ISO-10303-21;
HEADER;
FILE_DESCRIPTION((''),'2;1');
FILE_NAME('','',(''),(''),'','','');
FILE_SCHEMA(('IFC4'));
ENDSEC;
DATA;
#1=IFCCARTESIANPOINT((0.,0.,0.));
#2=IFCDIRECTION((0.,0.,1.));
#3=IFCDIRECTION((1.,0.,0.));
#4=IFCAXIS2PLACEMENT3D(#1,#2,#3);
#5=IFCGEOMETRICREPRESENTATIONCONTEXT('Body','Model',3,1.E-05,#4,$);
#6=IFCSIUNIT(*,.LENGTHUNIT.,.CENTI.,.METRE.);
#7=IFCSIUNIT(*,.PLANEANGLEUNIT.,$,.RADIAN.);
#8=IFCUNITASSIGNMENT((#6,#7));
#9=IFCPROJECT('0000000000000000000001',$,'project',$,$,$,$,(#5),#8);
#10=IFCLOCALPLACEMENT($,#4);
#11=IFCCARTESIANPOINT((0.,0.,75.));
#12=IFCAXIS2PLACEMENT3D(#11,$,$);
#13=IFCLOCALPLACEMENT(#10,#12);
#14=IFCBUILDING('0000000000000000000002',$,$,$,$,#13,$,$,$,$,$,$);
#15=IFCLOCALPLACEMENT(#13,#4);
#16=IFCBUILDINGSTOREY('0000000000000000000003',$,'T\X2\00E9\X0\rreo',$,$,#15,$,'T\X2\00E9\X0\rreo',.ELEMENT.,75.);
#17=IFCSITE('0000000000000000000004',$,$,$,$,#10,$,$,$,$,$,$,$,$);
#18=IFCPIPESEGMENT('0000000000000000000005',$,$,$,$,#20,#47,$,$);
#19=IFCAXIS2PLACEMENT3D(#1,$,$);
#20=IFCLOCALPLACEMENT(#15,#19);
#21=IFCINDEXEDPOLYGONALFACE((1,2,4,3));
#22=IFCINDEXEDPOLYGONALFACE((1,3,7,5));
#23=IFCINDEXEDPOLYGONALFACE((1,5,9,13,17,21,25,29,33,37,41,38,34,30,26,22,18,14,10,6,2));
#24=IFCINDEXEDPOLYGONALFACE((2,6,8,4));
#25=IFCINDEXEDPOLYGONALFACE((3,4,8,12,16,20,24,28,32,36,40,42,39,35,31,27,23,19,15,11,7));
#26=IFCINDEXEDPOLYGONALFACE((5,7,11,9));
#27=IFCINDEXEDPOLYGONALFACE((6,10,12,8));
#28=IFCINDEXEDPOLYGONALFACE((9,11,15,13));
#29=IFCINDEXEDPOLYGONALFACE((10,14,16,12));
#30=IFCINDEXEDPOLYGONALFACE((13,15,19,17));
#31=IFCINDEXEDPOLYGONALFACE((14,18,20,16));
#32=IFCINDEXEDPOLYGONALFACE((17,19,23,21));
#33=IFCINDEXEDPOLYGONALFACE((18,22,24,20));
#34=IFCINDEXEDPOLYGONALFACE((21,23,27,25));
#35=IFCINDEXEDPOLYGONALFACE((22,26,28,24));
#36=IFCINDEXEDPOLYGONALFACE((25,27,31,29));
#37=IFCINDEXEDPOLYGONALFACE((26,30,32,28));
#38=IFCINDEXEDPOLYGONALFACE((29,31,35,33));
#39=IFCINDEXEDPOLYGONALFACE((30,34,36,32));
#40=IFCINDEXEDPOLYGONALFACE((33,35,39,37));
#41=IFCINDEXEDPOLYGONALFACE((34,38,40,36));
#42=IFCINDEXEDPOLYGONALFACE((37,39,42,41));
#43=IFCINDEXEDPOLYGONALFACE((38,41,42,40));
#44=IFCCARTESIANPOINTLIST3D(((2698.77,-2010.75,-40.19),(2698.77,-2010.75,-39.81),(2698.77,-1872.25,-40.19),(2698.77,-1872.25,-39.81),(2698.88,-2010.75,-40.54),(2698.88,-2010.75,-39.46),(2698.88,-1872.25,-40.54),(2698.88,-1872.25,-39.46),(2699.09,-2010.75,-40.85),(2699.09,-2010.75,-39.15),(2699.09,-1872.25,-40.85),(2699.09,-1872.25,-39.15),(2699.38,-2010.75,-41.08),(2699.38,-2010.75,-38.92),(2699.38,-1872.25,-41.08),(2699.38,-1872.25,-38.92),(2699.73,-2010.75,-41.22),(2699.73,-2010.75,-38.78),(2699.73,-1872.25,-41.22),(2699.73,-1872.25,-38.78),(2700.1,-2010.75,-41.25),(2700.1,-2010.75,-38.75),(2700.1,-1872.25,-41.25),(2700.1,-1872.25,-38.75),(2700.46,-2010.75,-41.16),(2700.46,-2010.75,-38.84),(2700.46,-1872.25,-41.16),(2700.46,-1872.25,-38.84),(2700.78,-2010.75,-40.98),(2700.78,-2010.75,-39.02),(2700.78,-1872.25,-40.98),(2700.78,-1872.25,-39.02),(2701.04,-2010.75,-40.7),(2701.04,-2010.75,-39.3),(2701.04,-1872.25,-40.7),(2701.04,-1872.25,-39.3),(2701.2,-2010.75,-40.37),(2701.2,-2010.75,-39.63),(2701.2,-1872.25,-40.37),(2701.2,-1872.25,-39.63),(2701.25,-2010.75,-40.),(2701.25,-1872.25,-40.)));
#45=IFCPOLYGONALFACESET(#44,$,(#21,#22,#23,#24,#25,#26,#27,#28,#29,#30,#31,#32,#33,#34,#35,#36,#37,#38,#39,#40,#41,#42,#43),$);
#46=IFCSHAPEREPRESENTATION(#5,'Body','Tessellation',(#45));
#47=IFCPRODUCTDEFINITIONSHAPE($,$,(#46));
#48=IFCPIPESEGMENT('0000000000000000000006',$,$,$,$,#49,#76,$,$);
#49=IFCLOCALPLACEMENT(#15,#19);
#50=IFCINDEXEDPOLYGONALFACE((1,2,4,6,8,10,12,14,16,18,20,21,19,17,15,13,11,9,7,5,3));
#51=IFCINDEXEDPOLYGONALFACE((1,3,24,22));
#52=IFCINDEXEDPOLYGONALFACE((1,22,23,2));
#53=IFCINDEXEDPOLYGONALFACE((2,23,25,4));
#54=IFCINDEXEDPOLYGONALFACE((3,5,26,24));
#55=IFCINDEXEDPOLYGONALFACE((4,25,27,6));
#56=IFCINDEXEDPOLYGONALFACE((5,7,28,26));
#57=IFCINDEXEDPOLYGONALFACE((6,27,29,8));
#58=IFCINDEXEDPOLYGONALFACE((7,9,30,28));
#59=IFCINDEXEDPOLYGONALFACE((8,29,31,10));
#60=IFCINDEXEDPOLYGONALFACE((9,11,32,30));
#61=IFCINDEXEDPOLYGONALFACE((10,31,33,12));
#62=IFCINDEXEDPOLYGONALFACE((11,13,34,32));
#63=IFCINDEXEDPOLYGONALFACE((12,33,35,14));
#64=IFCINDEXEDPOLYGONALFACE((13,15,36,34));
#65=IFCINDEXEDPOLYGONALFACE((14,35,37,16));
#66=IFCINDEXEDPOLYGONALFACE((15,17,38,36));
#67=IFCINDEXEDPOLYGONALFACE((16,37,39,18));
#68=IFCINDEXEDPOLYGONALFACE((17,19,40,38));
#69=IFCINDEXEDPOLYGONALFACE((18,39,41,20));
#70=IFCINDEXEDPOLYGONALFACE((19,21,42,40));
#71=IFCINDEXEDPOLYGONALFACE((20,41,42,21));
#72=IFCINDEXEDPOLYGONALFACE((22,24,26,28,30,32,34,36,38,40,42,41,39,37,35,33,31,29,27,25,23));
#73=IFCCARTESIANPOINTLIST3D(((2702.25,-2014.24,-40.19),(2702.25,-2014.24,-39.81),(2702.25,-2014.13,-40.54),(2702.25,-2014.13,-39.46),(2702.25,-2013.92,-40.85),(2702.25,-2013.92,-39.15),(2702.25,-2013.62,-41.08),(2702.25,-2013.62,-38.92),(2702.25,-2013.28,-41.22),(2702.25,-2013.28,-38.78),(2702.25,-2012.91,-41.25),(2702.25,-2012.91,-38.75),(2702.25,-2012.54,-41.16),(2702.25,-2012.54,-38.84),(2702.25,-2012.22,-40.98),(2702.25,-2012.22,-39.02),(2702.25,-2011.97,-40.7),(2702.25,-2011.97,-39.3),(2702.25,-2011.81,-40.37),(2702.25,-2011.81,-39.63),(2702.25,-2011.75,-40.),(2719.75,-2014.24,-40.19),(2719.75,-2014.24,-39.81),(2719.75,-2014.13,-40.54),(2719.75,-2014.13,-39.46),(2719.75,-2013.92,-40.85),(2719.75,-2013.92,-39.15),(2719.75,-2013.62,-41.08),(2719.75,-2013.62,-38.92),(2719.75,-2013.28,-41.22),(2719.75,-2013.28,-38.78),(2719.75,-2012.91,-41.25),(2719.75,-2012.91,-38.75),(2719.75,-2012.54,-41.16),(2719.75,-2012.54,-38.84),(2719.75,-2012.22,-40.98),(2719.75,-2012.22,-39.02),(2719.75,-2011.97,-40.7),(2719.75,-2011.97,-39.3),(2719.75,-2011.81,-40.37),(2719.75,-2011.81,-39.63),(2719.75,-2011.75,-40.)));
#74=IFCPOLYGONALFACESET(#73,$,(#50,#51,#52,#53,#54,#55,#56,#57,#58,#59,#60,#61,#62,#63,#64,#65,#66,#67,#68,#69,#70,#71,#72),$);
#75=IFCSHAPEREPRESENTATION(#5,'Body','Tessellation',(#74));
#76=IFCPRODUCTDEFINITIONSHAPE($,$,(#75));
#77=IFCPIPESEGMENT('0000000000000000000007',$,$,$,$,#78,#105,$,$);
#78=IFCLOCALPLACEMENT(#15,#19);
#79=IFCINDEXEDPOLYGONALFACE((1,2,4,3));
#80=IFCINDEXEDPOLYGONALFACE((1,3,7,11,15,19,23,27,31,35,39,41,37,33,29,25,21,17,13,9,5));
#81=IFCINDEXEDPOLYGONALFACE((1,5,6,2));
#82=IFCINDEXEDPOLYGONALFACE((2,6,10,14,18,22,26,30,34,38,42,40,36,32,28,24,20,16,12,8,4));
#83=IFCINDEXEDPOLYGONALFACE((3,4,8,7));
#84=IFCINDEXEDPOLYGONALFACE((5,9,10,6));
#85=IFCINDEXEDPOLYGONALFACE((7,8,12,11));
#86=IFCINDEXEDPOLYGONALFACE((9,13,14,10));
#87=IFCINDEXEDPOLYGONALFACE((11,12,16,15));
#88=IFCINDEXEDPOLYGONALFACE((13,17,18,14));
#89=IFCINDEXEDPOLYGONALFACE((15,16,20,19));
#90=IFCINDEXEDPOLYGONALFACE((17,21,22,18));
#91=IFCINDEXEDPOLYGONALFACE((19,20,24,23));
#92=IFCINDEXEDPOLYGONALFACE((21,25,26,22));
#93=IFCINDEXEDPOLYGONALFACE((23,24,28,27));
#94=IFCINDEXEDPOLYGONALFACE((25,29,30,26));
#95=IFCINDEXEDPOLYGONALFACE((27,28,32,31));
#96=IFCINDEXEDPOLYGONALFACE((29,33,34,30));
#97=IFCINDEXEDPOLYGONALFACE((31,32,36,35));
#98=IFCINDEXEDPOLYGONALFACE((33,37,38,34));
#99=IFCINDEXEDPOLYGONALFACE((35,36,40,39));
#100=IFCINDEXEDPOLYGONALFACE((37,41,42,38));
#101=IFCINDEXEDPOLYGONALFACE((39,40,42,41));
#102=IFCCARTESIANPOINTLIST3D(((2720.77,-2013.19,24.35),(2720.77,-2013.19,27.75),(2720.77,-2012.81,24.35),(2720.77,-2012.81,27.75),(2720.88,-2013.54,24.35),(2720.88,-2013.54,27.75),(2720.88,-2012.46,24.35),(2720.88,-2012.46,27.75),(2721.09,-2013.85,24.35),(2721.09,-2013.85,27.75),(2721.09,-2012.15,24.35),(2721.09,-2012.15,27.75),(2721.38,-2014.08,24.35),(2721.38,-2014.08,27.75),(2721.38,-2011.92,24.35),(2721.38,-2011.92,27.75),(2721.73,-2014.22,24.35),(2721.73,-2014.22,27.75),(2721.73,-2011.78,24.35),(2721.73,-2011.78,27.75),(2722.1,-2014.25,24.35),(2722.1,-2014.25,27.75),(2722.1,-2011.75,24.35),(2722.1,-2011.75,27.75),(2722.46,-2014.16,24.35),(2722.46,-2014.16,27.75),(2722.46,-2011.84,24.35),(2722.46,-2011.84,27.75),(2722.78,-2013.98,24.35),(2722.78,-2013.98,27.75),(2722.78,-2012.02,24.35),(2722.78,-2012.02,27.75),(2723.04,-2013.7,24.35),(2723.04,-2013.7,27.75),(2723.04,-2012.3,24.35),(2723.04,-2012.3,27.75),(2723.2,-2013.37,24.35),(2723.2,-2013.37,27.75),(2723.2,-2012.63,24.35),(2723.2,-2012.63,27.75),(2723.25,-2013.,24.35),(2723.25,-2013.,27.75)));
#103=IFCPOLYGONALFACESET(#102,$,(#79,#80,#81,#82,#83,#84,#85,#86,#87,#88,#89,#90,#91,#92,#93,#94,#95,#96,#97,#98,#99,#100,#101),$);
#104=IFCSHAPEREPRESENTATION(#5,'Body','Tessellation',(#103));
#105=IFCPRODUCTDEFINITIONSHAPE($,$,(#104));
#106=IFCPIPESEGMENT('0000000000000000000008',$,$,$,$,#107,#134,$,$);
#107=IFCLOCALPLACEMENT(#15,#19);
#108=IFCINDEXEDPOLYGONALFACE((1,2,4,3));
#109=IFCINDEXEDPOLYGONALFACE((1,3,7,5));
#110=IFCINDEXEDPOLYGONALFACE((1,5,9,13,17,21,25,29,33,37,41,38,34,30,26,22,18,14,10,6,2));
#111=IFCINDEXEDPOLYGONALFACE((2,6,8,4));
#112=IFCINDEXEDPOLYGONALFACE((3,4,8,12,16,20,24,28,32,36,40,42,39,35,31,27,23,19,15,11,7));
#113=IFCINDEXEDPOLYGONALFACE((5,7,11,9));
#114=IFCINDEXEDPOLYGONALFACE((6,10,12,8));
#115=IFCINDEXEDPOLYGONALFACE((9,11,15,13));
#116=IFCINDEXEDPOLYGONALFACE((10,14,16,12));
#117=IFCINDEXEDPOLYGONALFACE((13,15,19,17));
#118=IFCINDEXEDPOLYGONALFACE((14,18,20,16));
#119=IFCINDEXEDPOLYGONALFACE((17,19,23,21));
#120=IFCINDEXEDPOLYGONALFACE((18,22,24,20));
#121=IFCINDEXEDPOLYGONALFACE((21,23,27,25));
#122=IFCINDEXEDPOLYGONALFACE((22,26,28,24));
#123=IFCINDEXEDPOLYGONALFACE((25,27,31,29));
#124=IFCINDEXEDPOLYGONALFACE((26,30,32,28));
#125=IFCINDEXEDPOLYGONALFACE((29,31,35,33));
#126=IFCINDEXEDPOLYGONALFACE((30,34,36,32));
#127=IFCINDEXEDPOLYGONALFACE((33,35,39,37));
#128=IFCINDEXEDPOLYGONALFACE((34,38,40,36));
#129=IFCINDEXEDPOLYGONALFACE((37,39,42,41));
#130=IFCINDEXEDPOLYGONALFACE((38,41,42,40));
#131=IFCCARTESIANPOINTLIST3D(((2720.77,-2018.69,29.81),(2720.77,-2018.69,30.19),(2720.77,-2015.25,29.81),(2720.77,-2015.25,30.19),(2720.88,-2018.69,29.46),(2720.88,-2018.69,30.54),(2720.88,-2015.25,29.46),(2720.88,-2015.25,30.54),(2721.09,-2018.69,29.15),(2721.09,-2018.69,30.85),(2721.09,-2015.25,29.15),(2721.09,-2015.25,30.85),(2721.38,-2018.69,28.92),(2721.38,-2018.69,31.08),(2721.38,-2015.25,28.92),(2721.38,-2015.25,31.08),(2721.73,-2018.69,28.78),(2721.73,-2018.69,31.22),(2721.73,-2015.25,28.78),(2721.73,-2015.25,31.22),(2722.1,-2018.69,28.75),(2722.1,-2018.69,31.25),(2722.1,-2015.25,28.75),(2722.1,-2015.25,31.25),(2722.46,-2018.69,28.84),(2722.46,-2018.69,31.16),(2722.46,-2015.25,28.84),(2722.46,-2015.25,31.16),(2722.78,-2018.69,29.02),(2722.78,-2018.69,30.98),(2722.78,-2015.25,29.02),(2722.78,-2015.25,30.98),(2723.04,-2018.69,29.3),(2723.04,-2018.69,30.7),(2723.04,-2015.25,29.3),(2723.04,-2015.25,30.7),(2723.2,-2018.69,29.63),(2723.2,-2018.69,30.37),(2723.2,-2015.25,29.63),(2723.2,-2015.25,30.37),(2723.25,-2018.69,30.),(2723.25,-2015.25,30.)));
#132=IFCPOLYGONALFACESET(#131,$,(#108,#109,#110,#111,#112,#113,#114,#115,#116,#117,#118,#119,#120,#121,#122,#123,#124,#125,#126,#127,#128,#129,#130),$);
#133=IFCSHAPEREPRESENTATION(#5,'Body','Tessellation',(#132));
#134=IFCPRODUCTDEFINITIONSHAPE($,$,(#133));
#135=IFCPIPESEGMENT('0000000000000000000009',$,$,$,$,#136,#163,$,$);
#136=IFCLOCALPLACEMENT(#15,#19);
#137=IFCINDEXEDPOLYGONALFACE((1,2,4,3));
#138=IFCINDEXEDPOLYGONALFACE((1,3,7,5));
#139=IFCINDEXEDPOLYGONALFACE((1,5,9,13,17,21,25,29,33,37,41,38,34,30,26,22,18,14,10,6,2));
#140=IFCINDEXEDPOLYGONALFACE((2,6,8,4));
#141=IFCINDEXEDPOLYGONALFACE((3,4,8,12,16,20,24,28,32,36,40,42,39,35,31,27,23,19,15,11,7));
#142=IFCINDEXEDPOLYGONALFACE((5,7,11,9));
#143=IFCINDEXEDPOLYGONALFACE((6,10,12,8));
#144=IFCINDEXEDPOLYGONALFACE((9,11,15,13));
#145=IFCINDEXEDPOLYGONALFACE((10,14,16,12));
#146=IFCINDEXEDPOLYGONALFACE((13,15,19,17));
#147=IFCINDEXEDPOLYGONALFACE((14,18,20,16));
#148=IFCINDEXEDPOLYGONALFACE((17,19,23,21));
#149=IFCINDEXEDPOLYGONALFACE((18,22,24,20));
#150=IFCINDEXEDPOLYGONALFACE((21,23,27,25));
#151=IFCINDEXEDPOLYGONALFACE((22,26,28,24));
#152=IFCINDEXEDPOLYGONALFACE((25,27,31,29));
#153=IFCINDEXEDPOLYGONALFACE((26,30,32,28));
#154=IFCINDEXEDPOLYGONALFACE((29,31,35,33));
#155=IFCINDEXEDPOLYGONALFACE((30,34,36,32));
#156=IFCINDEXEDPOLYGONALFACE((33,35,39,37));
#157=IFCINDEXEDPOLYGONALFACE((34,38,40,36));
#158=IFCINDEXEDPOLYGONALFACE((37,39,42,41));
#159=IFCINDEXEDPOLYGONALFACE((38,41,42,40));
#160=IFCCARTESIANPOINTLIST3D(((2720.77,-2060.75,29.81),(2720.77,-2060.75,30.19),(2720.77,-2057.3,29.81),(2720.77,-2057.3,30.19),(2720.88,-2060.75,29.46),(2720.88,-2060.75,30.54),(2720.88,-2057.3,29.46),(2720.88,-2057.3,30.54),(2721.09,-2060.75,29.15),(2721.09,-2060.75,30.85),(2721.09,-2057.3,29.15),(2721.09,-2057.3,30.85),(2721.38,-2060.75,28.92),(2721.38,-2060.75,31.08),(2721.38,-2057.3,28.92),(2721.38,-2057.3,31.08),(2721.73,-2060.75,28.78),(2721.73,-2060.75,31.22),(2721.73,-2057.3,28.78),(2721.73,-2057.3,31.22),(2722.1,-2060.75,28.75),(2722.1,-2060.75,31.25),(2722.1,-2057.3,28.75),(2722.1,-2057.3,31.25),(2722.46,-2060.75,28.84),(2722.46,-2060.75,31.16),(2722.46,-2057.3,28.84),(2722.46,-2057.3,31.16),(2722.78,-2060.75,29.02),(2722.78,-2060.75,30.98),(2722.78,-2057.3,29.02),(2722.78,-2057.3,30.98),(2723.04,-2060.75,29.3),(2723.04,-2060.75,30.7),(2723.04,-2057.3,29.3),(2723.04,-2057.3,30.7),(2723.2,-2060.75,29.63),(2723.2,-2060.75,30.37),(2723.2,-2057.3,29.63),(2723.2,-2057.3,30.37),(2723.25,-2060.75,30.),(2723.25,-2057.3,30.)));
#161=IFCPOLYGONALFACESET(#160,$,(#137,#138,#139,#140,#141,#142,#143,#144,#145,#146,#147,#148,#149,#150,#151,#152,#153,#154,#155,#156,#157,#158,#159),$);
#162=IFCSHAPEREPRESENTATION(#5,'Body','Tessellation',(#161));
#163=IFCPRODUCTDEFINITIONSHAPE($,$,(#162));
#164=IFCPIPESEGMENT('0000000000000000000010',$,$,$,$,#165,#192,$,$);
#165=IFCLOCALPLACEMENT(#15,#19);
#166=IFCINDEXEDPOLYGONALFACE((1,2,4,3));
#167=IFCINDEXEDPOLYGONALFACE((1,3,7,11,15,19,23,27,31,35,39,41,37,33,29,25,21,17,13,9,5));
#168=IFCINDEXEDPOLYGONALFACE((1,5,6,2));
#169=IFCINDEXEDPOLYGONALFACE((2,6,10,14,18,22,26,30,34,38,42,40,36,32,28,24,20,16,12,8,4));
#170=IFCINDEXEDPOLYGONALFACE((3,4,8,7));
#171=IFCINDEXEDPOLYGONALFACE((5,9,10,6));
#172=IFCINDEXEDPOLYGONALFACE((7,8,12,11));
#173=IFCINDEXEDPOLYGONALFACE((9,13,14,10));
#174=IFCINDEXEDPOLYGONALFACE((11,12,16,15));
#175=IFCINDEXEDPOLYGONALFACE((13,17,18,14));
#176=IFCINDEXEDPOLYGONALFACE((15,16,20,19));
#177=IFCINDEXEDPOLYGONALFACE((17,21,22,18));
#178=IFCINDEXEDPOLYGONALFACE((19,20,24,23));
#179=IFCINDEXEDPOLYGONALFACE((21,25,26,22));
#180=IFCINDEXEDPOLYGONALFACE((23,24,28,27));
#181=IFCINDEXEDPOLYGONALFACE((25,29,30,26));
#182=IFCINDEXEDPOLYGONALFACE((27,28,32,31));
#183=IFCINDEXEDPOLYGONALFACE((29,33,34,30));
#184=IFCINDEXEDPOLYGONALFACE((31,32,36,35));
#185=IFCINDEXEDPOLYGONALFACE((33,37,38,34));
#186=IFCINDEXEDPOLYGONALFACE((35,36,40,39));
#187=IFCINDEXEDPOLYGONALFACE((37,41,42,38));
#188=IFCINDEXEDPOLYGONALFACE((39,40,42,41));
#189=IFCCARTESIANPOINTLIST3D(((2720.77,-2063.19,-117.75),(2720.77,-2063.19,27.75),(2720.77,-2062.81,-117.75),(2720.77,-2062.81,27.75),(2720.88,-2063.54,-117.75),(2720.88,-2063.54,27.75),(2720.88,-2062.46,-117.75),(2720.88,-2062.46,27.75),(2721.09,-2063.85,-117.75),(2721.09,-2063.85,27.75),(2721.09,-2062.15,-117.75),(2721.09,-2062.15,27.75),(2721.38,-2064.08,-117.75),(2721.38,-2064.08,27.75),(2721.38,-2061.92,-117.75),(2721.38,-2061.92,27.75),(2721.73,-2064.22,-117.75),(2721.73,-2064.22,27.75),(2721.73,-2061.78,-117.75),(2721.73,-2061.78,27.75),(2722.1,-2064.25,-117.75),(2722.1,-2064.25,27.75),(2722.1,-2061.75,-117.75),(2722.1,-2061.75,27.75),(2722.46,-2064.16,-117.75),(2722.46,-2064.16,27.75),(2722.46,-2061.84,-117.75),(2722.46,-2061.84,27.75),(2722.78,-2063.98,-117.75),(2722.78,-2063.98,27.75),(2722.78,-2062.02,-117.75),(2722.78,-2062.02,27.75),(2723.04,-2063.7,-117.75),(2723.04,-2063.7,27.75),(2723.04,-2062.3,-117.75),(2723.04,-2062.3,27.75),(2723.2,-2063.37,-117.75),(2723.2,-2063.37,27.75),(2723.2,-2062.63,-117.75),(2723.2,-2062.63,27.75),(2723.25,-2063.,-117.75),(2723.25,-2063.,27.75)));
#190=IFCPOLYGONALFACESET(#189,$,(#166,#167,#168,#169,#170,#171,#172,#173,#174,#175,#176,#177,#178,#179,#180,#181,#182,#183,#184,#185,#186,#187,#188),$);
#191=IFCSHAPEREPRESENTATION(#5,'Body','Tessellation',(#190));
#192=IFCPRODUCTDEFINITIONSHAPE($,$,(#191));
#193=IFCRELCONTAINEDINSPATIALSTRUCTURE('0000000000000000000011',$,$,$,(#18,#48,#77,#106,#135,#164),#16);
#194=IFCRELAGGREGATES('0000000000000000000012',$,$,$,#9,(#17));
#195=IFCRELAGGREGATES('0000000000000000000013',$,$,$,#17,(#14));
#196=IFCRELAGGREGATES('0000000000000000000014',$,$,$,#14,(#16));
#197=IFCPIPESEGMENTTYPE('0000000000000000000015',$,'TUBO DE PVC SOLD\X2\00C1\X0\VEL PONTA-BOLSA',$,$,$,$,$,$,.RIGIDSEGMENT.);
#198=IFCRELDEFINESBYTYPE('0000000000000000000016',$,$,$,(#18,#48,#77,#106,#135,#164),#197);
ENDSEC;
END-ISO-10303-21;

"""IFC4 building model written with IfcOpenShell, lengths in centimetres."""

from ifc_helpers import new_model, si_unit, frame, origin_with_axes, origin_2d_with_axis, place, context, project, spatial, circle, extrude, type_object, element, save


model = new_model("IFC4")

# Units and contexts
model_context = context("Model", 3, precision=1e-05, world=origin_with_axes(), identifier="Body")
ifc_project = project(units=[si_unit("LENGTHUNIT", "METRE", prefix="CENTI"), si_unit("PLANEANGLEUNIT", "RADIAN")], contexts=[model_context])

# Site, building, storey
site_placement = place(None, origin_with_axes())
site = spatial("IfcSite", under=ifc_project, at=site_placement)
building_placement = place(site_placement, frame((0.0, 0.0, 75.0)))
building = spatial("IfcBuilding", under=site, at=building_placement)
storey_placement = place(building_placement, origin_with_axes())
storey = spatial("IfcBuildingStorey", under=building, at=storey_placement, Name="Térreo", LongName="Térreo", CompositionType="ELEMENT", Elevation=75.0)

# Pipe segments
pipe_segment_type_1 = type_object("IfcPipeSegmentType", Name="TUBO DE PVC SOLDÁVEL PONTA-BOLSA", PredefinedType="RIGIDSEGMENT")
pipe_segment_1_placement = place(storey_placement, frame((2700.0, -1941.5, -38.75), z_axis=(0.0, 0.0, 1.0), x_axis=(1.0, 0.0, 0.0)))
element("IfcPipeSegment", 1, at=pipe_segment_1_placement, inside=storey, type_object=pipe_segment_type_1, context=model_context, shape_type="SolidModel", body=[
    extrude(circle(Radius=1.25, at=origin_2d_with_axis()), frame((0.0, -69.25, -1.25), z_axis=(0.0, 1.0, 0.0), x_axis=(1.0, 0.0, 0.0)), (0.0, 0.0, 1.0), 138.5),
])
pipe_segment_2_placement = place(storey_placement, frame((2711.0, -2013.0, -38.75), z_axis=(0.0, 0.0, 1.0), x_axis=(1.0, 0.0, 0.0)))
element("IfcPipeSegment", 2, at=pipe_segment_2_placement, inside=storey, type_object=pipe_segment_type_1, context=model_context, shape_type="SolidModel", body=[
    extrude(circle(Radius=1.25, at=origin_2d_with_axis()), frame((8.75, 0.0, -1.25), z_axis=(-1.0, 0.0, 0.0), x_axis=(0.0, 1.0, 0.0)), (0.0, 0.0, 1.0), 17.5),
])
pipe_segment_3_placement = place(storey_placement, frame((2722.0, -2013.0, 27.75), z_axis=(0.0, 0.0, 1.0), x_axis=(1.0, 0.0, 0.0)))
element("IfcPipeSegment", 3, at=pipe_segment_3_placement, inside=storey, type_object=pipe_segment_type_1, context=model_context, shape_type="SolidModel", body=[
    extrude(circle(Radius=1.25, at=origin_2d_with_axis()), frame((0.0, 0.0, 0.0), z_axis=(0.0, 0.0, -1.0), x_axis=(1.0, 0.0, 0.0)), (0.0, 0.0, 1.0), 3.4),
])
for number, where, z_axis, x_axis in (
    (4, (2722.0, -2016.97, 31.25), (0.0, 0.0, 1.0), (1.0, 0.0, 0.0)),
    (5, (2722.0, -2059.03, 31.25), (0.0, 0.0, 1.0), (1.0, 0.0, 0.0)),
):
    element("IfcPipeSegment", number, at=place(storey_placement, frame(where, z_axis=z_axis, x_axis=x_axis)), inside=storey, type_object=pipe_segment_type_1, context=model_context, shape_type="SolidModel", body=[
        extrude(circle(Radius=1.25, at=origin_2d_with_axis()), frame((0.0, -1.72, -1.25), z_axis=(0.0, 1.0, 0.0), x_axis=(1.0, 0.0, 0.0)), (0.0, 0.0, 1.0), 3.44),
    ])
pipe_segment_4_placement = place(storey_placement, frame((2722.0, -2063.0, 27.75), z_axis=(0.0, 0.0, 1.0), x_axis=(1.0, 0.0, 0.0)))
element("IfcPipeSegment", 6, at=pipe_segment_4_placement, inside=storey, type_object=pipe_segment_type_1, context=model_context, shape_type="SolidModel", body=[
    extrude(circle(Radius=1.25, at=origin_2d_with_axis()), frame((0.0, 0.0, -145.5), z_axis=(0.0, 0.0, 1.0), x_axis=(1.0, 0.0, 0.0)), (0.0, 0.0, 1.0), 145.5),
])

save(model, "model.ifc")
